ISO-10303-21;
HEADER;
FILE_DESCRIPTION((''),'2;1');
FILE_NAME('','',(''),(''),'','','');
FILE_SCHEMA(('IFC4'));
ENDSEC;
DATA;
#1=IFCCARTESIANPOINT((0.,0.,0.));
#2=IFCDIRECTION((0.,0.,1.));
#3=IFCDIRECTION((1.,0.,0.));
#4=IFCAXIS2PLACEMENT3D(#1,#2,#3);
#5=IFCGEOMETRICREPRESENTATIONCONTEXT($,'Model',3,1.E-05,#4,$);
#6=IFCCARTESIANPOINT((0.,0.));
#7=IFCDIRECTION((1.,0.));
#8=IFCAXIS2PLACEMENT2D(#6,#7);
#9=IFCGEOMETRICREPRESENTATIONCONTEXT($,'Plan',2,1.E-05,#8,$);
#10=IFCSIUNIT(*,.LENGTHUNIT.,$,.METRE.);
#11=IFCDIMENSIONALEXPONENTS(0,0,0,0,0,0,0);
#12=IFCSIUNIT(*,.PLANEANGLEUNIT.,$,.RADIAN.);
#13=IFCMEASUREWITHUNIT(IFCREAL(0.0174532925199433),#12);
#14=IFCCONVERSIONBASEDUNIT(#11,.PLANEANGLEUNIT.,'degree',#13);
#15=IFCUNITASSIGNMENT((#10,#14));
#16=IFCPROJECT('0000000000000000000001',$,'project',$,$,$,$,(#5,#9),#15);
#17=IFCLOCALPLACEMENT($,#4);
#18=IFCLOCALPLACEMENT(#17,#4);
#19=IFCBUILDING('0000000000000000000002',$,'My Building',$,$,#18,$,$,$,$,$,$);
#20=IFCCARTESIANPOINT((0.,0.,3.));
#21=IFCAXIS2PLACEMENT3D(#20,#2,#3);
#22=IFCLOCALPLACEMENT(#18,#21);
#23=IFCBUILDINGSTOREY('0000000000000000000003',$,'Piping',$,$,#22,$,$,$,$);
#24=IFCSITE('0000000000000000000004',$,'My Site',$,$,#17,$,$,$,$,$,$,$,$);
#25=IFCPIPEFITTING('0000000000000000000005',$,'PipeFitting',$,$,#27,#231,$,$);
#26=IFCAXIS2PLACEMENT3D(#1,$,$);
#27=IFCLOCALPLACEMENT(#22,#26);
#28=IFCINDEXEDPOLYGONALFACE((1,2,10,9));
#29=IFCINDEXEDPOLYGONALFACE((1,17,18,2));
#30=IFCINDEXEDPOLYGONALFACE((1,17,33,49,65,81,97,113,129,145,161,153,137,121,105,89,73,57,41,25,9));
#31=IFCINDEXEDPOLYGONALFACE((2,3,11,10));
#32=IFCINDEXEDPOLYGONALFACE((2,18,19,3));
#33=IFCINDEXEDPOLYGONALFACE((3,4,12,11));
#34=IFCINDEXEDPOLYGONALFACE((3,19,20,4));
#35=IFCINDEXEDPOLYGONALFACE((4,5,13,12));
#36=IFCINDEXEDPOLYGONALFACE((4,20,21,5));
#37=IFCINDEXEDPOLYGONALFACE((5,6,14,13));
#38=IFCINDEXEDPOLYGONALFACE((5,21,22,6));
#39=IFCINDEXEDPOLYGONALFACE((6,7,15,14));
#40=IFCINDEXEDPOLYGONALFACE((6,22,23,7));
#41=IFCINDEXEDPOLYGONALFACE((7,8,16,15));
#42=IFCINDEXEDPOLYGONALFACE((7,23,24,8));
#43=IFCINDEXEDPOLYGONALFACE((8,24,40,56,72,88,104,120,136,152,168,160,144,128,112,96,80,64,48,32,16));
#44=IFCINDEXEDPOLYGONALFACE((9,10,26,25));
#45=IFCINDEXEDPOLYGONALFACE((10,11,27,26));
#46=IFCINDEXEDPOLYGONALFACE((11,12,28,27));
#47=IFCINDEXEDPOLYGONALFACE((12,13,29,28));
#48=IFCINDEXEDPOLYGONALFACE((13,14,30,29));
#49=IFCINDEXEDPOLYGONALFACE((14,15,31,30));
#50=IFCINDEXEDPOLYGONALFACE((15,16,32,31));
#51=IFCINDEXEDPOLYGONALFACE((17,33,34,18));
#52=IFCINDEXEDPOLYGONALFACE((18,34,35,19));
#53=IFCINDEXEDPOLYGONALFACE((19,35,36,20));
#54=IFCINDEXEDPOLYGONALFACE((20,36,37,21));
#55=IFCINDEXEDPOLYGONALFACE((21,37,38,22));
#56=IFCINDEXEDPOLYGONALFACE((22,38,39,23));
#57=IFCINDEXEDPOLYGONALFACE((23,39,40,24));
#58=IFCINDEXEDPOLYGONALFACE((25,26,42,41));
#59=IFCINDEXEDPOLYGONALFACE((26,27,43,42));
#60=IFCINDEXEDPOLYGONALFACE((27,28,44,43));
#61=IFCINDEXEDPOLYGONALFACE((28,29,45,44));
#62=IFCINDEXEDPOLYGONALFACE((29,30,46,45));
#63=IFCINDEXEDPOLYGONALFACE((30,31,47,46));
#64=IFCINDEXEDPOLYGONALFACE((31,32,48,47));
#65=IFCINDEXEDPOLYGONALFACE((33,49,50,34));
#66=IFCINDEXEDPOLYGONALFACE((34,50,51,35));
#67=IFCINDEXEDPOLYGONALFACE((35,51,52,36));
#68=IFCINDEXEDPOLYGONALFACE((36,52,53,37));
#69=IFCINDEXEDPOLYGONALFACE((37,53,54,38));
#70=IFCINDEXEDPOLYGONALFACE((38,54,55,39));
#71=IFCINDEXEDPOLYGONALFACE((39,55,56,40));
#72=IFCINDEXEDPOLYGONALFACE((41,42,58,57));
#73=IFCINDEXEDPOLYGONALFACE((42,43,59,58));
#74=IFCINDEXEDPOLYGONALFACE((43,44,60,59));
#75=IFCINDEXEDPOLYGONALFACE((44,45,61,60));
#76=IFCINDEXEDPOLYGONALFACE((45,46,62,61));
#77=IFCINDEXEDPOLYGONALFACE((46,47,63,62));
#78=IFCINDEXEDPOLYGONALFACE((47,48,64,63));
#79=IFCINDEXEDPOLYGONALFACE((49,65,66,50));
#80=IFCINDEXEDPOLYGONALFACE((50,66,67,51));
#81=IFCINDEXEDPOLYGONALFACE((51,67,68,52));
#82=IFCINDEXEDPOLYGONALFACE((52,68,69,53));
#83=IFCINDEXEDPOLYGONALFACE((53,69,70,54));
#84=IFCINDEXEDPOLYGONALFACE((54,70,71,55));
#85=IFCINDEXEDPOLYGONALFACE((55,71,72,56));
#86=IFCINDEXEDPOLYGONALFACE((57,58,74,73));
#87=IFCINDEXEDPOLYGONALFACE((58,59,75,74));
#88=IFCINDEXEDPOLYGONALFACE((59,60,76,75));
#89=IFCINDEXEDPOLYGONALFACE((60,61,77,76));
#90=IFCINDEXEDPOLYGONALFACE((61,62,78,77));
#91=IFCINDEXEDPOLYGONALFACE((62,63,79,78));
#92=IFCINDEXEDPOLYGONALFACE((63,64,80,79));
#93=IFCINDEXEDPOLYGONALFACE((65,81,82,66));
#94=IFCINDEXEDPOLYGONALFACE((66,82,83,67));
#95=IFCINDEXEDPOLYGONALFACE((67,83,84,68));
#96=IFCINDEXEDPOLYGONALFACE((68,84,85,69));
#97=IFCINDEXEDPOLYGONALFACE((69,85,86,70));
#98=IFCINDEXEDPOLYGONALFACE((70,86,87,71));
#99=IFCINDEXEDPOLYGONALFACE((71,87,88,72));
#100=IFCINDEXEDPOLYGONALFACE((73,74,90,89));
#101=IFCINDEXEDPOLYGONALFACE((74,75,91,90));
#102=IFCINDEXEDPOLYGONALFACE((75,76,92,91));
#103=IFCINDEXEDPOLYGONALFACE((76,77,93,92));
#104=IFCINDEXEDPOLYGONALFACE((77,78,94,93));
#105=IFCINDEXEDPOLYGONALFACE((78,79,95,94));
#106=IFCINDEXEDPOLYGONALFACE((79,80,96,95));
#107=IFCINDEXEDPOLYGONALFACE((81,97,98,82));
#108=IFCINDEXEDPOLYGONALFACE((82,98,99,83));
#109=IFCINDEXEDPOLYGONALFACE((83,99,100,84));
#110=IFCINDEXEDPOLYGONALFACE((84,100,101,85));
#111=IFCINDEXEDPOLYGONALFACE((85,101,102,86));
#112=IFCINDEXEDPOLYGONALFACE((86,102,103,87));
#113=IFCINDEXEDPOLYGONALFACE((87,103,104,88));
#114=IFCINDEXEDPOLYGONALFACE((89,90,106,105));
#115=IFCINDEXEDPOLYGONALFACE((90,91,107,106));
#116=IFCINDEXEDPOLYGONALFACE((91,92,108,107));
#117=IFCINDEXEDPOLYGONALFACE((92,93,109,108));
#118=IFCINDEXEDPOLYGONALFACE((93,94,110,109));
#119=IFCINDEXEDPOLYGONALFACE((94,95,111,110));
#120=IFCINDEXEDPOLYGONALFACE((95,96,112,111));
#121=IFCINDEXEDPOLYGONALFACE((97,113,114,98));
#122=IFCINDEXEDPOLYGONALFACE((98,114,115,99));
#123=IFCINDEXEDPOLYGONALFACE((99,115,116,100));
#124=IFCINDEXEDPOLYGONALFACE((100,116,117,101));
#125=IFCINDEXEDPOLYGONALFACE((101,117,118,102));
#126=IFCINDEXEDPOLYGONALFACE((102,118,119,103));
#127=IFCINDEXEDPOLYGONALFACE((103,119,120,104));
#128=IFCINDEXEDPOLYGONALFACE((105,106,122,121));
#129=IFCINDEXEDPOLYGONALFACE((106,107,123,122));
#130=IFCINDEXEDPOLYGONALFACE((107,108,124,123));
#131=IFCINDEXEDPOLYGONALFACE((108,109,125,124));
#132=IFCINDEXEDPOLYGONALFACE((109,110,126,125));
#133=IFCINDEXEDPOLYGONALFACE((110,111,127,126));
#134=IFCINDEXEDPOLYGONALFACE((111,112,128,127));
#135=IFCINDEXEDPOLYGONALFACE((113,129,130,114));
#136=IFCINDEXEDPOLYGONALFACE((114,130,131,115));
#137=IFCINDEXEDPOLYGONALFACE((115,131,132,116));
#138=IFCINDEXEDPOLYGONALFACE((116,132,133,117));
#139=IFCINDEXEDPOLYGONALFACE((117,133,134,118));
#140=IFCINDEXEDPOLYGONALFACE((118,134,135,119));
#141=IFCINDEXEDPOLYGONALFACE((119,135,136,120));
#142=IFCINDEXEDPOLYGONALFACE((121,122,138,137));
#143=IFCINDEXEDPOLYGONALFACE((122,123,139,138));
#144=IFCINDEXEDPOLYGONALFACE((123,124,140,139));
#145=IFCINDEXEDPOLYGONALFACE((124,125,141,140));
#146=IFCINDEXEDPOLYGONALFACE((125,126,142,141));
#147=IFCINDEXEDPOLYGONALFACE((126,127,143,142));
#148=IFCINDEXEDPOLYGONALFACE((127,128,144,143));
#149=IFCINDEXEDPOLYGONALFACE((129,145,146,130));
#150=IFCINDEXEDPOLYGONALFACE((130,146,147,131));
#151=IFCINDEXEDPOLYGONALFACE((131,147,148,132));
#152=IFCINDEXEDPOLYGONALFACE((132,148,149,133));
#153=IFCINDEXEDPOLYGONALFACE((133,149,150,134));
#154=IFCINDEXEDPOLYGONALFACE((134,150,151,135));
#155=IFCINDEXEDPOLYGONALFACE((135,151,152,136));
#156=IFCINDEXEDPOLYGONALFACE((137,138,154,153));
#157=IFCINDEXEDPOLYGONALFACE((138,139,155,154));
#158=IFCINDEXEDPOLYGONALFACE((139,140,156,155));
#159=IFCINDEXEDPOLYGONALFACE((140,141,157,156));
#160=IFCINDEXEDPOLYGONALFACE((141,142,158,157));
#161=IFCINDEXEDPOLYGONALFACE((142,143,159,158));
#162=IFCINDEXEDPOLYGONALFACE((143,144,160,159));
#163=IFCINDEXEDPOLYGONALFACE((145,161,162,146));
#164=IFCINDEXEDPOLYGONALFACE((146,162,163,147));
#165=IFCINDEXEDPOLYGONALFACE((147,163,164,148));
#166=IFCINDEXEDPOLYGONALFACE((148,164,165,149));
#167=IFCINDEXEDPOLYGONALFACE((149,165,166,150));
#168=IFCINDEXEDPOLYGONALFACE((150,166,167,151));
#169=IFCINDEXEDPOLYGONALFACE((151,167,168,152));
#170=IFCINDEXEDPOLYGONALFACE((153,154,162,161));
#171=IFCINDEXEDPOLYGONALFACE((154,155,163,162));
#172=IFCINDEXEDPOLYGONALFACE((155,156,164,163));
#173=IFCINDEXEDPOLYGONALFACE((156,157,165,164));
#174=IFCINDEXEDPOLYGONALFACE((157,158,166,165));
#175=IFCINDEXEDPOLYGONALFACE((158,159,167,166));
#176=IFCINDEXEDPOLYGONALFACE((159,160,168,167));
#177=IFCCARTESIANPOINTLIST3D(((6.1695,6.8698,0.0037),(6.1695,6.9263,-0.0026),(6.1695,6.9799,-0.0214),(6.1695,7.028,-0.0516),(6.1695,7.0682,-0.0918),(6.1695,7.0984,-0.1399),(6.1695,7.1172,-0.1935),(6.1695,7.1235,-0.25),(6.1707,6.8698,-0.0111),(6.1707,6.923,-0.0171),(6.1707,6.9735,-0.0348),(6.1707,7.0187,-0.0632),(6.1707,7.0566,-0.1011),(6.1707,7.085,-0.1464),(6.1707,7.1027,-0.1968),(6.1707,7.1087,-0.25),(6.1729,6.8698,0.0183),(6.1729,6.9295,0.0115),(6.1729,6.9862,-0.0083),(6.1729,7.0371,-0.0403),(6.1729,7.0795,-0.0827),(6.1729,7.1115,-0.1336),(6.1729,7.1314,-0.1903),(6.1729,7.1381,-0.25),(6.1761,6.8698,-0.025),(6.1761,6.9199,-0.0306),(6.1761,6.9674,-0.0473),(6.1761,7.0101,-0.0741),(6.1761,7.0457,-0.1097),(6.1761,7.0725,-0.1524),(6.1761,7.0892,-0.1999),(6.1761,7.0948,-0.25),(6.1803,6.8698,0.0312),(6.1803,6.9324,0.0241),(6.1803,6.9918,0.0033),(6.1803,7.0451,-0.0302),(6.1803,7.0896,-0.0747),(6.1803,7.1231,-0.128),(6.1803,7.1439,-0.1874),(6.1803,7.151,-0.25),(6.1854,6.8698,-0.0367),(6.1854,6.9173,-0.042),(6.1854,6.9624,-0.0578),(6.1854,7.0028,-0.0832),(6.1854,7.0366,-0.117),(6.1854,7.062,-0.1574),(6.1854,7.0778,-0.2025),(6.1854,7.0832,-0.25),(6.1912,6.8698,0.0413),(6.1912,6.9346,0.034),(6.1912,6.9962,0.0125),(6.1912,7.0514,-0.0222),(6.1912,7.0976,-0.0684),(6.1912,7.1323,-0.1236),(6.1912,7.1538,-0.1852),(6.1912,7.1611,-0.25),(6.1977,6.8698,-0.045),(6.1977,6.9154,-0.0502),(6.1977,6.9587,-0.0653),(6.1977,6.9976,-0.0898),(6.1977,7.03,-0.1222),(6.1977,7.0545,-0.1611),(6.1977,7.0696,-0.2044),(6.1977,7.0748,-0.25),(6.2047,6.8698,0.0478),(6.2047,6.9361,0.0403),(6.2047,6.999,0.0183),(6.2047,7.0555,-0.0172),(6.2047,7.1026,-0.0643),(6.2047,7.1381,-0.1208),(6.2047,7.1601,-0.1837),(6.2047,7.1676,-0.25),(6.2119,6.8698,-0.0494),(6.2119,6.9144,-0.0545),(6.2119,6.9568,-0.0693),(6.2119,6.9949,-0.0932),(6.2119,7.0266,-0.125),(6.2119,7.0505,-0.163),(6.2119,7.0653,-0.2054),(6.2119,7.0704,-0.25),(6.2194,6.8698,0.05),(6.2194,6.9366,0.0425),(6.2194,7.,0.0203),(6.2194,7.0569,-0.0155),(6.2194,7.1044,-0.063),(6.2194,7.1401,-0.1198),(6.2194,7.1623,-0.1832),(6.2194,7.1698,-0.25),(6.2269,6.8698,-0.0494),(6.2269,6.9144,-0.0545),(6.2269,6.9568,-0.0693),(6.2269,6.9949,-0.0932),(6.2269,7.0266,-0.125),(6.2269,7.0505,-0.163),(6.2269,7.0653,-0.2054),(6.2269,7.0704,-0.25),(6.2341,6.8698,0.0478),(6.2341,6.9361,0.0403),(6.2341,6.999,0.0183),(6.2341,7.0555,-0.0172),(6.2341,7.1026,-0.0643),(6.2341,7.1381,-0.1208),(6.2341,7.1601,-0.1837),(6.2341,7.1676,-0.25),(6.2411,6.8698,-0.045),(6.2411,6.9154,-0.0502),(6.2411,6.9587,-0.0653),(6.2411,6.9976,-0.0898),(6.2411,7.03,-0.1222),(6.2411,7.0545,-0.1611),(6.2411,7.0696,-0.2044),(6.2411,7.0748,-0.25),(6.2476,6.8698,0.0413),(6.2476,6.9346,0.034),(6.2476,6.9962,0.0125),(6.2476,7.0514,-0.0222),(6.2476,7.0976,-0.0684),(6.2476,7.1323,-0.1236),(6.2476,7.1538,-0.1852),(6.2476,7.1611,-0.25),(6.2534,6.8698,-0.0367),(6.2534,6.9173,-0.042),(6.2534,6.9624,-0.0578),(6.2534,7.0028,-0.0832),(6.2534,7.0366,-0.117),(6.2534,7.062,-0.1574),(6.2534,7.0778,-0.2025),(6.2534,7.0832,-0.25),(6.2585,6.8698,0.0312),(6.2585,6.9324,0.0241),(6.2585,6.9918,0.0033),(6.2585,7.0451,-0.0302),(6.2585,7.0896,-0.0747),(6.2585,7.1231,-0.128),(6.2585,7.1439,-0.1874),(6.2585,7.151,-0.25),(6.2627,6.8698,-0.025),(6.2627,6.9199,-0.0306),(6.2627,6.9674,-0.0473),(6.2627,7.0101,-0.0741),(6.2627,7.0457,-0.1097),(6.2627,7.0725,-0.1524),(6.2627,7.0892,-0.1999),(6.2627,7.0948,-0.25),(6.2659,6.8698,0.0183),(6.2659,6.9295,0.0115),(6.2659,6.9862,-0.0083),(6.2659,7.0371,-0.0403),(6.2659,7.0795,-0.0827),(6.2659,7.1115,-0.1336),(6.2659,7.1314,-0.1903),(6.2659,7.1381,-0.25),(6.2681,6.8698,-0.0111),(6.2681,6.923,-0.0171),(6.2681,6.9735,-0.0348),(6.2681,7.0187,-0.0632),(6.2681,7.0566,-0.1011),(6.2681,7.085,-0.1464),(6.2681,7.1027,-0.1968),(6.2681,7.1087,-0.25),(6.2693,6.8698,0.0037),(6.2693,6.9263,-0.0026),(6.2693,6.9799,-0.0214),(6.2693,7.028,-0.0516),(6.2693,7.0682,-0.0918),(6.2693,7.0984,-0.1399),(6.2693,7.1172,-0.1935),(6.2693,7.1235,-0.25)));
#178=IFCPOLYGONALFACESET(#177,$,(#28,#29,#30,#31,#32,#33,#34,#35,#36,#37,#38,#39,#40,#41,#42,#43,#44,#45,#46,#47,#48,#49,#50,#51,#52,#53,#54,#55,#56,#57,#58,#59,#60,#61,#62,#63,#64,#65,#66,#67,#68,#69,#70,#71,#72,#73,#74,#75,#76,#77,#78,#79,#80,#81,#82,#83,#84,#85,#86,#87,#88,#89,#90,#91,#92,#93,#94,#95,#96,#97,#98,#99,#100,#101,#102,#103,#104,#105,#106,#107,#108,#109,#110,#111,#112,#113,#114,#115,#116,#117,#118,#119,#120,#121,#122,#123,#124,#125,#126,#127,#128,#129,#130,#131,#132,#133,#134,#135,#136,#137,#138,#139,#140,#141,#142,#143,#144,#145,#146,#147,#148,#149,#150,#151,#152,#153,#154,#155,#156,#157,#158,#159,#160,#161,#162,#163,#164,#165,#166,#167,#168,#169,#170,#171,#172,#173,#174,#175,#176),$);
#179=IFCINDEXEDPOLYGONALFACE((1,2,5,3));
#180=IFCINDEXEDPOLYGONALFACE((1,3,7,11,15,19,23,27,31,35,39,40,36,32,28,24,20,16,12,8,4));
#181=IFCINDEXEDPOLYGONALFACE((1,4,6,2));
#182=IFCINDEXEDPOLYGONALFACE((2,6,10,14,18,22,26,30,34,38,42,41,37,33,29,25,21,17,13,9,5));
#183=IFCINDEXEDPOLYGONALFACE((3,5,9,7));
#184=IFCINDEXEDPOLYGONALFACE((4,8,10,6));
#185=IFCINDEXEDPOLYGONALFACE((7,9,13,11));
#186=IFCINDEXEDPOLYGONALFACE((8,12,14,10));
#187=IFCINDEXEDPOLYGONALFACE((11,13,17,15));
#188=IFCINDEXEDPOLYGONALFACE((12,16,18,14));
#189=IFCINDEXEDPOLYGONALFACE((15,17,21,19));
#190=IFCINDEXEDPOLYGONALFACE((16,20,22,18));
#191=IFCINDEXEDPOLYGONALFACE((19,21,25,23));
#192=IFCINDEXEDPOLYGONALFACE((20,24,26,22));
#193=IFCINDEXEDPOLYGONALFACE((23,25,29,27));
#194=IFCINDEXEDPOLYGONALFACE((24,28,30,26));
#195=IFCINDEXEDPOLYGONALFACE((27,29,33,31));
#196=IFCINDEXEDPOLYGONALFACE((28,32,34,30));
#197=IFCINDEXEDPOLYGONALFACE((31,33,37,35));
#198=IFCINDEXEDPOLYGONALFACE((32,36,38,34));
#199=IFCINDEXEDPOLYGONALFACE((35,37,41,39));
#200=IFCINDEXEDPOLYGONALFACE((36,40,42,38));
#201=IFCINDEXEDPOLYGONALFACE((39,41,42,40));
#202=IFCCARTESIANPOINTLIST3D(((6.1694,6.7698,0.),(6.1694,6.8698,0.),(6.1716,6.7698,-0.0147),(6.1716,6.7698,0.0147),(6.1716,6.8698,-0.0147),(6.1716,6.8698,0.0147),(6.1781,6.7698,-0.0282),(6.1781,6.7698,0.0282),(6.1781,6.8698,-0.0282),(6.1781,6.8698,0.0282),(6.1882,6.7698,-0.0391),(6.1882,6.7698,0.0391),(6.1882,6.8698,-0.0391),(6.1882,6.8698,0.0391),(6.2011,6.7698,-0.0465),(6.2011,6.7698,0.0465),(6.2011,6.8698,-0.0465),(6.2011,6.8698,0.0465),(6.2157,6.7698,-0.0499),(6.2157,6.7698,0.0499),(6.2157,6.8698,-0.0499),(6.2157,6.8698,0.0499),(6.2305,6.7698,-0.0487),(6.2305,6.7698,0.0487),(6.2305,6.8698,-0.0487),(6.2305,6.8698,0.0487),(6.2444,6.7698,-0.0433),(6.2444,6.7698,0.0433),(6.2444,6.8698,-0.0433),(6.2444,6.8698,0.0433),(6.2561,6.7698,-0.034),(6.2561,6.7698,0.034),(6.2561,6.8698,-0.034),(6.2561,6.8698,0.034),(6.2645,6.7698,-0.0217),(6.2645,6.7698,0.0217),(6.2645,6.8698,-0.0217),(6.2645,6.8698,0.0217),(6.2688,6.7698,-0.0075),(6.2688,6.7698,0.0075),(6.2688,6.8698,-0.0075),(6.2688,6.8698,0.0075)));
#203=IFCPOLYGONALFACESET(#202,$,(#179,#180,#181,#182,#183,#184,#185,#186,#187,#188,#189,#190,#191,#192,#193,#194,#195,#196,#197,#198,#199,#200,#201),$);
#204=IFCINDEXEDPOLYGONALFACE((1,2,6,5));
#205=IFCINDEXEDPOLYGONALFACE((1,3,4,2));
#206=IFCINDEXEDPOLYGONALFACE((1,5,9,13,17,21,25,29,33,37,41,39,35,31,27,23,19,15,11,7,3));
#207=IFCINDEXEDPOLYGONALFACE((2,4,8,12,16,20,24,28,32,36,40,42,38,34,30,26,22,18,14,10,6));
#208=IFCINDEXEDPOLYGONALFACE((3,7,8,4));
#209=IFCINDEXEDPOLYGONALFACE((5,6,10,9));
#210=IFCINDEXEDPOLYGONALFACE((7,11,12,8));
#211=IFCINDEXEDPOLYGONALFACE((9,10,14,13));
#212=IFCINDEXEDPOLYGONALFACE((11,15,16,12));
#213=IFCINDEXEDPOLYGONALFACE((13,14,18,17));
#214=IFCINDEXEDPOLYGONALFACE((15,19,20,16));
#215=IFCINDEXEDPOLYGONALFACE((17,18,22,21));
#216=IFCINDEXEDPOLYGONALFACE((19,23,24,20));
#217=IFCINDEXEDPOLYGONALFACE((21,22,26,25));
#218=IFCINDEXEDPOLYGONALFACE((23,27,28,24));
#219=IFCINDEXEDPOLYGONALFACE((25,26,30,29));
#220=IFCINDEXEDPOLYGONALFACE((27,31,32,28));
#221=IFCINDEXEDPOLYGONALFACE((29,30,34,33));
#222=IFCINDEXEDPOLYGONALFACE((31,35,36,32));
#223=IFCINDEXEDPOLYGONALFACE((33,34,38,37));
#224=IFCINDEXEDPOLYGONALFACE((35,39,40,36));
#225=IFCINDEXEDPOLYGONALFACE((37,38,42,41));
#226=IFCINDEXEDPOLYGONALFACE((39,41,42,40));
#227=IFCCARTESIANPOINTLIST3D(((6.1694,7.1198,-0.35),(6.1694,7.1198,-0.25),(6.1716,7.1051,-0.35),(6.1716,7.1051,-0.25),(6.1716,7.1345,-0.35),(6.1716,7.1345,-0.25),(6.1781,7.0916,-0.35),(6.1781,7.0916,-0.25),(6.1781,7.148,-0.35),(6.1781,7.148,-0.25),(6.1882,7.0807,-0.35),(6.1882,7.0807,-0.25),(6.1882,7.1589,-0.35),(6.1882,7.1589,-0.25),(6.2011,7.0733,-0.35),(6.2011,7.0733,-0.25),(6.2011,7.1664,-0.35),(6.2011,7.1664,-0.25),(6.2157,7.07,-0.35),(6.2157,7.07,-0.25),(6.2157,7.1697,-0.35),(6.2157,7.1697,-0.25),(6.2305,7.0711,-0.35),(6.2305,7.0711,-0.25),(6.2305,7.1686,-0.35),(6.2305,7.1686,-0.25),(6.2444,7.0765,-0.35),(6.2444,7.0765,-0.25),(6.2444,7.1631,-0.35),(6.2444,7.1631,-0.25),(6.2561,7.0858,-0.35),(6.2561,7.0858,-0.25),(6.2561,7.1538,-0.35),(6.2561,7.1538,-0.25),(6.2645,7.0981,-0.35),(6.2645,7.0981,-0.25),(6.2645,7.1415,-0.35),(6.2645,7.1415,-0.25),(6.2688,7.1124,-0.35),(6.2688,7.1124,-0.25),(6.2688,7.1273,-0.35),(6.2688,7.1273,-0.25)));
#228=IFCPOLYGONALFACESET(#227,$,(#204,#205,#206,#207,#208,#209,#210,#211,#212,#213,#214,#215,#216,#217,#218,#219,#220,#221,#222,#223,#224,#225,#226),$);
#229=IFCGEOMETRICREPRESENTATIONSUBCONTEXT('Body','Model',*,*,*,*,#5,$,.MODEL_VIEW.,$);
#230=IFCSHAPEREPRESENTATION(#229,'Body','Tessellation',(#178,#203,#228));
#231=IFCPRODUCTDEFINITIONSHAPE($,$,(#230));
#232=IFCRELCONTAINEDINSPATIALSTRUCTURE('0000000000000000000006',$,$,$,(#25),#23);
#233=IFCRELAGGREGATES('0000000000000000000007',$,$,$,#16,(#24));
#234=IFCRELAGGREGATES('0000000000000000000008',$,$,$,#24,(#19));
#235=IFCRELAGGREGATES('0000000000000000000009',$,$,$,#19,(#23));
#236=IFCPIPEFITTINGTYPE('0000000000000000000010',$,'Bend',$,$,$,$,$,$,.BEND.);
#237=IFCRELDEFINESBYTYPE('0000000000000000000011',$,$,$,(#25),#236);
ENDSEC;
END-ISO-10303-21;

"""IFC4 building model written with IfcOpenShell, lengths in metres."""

from ifc_helpers import new_model, entity, si_unit, converted_unit, frame, origin_with_axes, origin_2d_with_axis, place, context, subcontext, project, spatial, line, indexed_curve, circle, outline, extrude, source, transform, mapped, type_object, type_shapes, element, save


model = new_model("IFC4")

# Units and contexts
model_context = context("Model", 3, precision=1e-05, world=origin_with_axes())
plan_context = context("Plan", 2, precision=1e-05, world=origin_2d_with_axis())
body_context = subcontext(model_context, "Body", "Model", "MODEL_VIEW")
ifc_project = project(units=[si_unit("LENGTHUNIT", "METRE"), converted_unit("PLANEANGLEUNIT", "degree", entity("IfcReal", 0.0174532925199433), si_unit("PLANEANGLEUNIT", "RADIAN"), dimensions=[0, 0, 0, 0, 0, 0, 0])], contexts=[model_context, plan_context])

# Site, building, storey
site_placement = place(None, origin_with_axes())
site = spatial("IfcSite", under=ifc_project, at=site_placement, Name="My Site")
building_placement = place(site_placement, origin_with_axes())
building = spatial("IfcBuilding", under=site, at=building_placement, Name="My Building")
storey_placement = place(building_placement, frame((0.0, 0.0, 3.0), z_axis=(0.0, 0.0, 1.0), x_axis=(1.0, 0.0, 0.0)))
storey = spatial("IfcBuildingStorey", under=building, at=storey_placement, Name="Piping")

# Pipe fitting, opening
pipe_fitting_type = type_object("IfcPipeFittingType", Name="Bend", PredefinedType="BEND")
shared_shape = source(origin_with_axes(), body_context, "Body", "SolidModel", [
    entity("IfcSweptDiskSolid", entity("IfcIndexedPolyCurve", entity("IfcCartesianPointList3D", [[0.0, 0.0, 0.1], [0.0, -0.0732, 0.2768], [0.0, -0.25, 0.35]]), [entity("IfcArcIndex", [1, 2, 3])]), 0.05),
    extrude(circle(Radius=0.05), origin_with_axes(), (0.0, 0.0, 1.0), 0.1),
    extrude(circle(Radius=0.05), frame((0.0, -0.25, 0.35), z_axis=(0.0, -1.0, 0.0), x_axis=(1.0, 0.0, 0.0)), (0.0, 0.0, 1.0), 0.1),
])
type_shapes(pipe_fitting_type, [shared_shape])
pipe_fitting_1_placement = place(storey_placement, frame((6.2194, 6.7698, 0.0), z_axis=(0.0, 1.0, 0.0), x_axis=(-1.0, 0.0, 0.0)))
pipe_fitting_1 = element("IfcPipeFitting", 1, at=pipe_fitting_1_placement, inside=storey, type_object=pipe_fitting_type, Name="PipeFitting", context=body_context, shape_type="MappedRepresentation", body=[
    mapped(shared_shape, transform((0.0, 0.0, 0.0), x_axis=(1.0, 0.0, 0.0), y_axis=(0.0, 1.0, 0.0), z_axis=(0.0, 0.0, 1.0), scale=1.0)),
])
opening_1_placement = place(pipe_fitting_1_placement, frame((6.2194, -3.0, -6.7698), z_axis=(0.0, 1.0, 0.0), x_axis=(-1.0, 0.0, 0.0)))
element("IfcOpeningElement", 2, at=opening_1_placement, cuts=pipe_fitting_1, PredefinedType="OPENING", context=body_context, shape_type="SweptSolid", body=[
    extrude(outline(indexed_curve([(0.0, 0.0), (0.5, 0.0), (0.5, 0.5), (0.0, 0.5)], segments=[line(1, 2, 3, 4, 1)])), origin_with_axes(), (0.0, 0.0, 1.0), 0.5),
])

save(model, "model.ifc")
